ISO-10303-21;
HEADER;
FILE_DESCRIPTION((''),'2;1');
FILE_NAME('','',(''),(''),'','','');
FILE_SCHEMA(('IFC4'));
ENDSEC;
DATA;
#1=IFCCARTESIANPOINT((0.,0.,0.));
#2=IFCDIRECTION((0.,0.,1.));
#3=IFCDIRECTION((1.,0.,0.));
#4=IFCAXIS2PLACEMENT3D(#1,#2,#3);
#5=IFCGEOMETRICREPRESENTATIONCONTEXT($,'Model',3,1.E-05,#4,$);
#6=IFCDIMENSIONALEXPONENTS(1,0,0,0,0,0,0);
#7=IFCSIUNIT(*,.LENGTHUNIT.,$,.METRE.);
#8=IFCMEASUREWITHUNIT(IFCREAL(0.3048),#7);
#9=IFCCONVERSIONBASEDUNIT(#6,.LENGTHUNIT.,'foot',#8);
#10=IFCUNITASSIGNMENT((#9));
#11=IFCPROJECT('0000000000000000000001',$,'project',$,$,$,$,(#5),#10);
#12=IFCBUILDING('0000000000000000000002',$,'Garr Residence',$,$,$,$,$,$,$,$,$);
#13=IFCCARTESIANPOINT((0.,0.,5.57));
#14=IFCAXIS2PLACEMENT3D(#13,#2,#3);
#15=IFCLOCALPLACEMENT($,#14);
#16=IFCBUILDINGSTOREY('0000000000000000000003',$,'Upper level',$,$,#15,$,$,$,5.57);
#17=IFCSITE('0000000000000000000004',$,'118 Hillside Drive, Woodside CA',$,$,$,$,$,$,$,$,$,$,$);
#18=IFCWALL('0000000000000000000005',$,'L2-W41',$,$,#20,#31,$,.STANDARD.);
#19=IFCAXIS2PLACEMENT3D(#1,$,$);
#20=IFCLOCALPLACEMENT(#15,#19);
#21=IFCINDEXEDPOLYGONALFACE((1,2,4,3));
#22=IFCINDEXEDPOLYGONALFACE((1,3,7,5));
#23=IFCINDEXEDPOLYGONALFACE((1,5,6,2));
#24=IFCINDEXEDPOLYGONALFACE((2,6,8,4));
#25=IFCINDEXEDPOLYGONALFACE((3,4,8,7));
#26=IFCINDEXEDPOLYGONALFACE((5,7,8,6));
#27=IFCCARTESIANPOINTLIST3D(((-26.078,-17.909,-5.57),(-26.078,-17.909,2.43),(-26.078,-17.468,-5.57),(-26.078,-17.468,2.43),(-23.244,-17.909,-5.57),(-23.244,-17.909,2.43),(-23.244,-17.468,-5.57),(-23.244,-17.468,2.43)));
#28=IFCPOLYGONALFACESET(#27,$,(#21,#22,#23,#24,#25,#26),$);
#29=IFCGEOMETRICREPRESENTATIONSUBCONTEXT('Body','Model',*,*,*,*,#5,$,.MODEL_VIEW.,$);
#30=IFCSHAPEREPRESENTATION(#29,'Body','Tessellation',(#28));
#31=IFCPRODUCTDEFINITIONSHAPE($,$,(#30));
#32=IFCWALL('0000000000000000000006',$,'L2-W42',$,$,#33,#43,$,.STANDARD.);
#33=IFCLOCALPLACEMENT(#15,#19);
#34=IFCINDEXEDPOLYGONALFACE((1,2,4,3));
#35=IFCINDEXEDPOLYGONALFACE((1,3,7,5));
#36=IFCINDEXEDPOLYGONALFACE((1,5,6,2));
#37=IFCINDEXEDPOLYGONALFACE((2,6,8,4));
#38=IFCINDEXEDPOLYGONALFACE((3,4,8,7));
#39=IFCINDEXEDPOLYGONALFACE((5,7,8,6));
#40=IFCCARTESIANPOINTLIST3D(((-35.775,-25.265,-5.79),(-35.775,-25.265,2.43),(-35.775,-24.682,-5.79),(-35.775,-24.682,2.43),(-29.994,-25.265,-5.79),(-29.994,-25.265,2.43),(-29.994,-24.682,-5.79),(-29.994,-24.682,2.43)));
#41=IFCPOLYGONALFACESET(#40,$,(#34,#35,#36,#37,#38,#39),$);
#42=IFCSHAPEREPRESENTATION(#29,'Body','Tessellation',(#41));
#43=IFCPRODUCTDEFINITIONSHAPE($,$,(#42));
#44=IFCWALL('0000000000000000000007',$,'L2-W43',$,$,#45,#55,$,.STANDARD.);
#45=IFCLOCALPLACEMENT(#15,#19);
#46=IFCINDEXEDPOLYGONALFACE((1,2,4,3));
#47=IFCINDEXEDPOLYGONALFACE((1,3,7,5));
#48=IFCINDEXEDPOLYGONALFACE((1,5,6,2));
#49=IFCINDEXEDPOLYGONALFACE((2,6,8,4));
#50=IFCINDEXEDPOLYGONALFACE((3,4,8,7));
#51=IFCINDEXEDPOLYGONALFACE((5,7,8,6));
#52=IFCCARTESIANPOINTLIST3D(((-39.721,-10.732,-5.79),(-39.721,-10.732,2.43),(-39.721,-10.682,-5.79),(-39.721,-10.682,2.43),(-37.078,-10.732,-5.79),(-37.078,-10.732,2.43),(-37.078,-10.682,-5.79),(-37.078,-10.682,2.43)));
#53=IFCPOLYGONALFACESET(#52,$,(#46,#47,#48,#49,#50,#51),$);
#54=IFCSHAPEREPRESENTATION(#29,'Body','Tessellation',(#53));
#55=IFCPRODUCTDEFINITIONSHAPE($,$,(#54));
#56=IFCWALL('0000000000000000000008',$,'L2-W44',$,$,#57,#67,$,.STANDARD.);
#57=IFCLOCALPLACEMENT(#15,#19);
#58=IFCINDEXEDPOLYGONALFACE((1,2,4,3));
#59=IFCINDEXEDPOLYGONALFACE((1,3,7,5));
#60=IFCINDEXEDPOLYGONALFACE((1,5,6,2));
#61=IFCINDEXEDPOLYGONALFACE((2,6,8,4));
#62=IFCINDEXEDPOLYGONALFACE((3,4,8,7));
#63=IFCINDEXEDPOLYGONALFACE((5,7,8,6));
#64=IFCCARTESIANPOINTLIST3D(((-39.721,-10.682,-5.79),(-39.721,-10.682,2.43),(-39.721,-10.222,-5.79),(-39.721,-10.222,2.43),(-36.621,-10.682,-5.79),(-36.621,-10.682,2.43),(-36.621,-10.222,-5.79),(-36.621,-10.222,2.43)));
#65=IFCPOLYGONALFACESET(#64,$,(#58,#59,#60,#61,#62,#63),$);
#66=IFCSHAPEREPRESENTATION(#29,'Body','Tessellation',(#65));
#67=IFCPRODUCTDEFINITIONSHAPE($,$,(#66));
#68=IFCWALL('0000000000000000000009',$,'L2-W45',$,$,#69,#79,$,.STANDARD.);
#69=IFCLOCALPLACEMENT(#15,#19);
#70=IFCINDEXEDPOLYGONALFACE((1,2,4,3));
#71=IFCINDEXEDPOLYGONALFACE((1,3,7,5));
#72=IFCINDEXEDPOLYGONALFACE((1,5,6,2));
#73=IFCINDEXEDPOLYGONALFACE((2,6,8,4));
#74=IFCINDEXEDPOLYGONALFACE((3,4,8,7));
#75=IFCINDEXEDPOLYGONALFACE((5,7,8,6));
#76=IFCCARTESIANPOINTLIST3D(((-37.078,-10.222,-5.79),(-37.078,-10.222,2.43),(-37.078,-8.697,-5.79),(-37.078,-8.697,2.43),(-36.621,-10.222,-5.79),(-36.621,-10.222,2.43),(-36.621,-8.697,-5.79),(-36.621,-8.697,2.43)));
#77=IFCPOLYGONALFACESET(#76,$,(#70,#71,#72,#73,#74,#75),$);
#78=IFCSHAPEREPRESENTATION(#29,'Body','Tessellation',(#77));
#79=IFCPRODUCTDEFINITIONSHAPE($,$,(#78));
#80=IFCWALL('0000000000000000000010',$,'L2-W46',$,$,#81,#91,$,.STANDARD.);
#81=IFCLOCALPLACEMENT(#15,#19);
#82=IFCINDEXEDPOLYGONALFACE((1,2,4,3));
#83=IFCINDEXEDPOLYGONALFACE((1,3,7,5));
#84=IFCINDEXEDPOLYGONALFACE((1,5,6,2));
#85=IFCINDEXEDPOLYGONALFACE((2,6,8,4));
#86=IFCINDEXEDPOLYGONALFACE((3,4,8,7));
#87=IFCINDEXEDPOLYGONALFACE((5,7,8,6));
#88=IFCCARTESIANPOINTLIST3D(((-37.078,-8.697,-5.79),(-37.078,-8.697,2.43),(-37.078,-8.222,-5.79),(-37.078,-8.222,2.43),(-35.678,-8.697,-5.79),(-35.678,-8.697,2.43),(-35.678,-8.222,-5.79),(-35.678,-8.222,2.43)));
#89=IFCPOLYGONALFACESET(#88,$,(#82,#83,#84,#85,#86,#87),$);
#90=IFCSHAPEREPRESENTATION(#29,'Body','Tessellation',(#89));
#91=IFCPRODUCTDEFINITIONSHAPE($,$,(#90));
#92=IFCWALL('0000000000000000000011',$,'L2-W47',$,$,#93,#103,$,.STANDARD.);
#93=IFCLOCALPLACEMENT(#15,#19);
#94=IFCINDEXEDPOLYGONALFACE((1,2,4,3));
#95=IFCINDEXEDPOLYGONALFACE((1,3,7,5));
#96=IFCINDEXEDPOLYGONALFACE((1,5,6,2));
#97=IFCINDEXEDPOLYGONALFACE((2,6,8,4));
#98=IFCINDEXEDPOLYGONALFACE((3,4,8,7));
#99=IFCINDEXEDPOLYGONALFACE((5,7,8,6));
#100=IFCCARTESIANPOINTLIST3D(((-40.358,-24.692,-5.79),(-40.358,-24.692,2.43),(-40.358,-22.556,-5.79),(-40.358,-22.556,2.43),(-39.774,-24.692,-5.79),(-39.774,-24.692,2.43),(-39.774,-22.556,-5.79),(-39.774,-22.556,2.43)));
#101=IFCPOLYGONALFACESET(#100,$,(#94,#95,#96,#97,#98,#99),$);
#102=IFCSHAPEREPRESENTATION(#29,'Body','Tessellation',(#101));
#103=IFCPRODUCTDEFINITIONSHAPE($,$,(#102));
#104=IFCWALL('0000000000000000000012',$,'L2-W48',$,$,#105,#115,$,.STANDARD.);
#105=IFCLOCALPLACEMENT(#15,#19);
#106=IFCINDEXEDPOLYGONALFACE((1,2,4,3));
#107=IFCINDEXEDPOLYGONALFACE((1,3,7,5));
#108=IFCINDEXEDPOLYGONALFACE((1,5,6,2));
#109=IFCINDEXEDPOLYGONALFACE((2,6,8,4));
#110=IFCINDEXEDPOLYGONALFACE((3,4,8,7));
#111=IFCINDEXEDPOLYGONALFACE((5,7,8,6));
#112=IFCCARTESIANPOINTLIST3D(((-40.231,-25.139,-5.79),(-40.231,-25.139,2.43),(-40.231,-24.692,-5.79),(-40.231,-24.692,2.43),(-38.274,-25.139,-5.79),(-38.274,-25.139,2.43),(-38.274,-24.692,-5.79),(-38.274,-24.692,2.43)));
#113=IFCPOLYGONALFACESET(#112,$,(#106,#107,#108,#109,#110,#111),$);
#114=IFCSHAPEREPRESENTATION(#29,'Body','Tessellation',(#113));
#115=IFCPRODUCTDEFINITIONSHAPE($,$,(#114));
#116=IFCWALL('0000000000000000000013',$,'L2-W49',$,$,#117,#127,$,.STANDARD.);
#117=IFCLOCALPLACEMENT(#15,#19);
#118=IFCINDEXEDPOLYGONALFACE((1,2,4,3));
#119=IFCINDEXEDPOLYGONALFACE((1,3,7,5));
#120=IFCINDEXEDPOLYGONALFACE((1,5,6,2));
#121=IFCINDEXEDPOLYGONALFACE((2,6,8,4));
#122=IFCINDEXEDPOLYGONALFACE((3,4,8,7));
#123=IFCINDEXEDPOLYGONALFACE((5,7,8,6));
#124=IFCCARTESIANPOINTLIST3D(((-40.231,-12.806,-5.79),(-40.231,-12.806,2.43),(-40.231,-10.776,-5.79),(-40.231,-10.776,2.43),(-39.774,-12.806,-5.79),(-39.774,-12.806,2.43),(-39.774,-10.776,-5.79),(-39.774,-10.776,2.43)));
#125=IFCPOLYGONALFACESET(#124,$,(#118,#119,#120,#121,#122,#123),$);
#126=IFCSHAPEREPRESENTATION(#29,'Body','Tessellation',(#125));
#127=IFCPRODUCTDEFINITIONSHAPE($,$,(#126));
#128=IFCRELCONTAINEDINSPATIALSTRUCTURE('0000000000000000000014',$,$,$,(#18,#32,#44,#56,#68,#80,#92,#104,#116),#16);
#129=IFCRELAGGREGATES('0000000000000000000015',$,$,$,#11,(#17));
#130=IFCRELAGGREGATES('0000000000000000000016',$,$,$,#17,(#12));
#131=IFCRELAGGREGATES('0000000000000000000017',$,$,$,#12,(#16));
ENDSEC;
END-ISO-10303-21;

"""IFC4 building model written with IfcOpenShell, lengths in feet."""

from ifc_helpers import new_model, entity, si_unit, converted_unit, frame, origin, origin_with_axes, place, context, subcontext, project, spatial, polyline, outline, extrude, element, save


model = new_model("IFC4")

# Units and contexts
model_context = context("Model", 3, precision=1e-05, world=origin_with_axes())
body_context = subcontext(model_context, "Body", "Model", "MODEL_VIEW")
ifc_project = project(units=[converted_unit("LENGTHUNIT", "foot", entity("IfcReal", 0.3048), si_unit("LENGTHUNIT", "METRE"), dimensions=[1, 0, 0, 0, 0, 0, 0])], contexts=[model_context])

# Site, building, storey
site = spatial("IfcSite", under=ifc_project, Name="118 Hillside Drive, Woodside CA")
building = spatial("IfcBuilding", under=site, Name="Garr Residence")
storey_placement = place(None, frame((0.0, 0.0, 5.57), z_axis=(0.0, 0.0, 1.0), x_axis=(1.0, 0.0, 0.0)))
storey = spatial("IfcBuildingStorey", under=building, at=storey_placement, Name="Upper level", Elevation=5.57)

# Walls
wall_1_placement = place(storey_placement, frame((0.0, 0.0, -5.57), z_axis=(0.0, 0.0, 1.0), x_axis=(1.0, 0.0, 0.0)))
element("IfcWall", 1, at=wall_1_placement, inside=storey, Name="L2-W41", PredefinedType="STANDARD", context=body_context, shape_type="SweptSolid", body=[
    extrude(outline(polyline([(-23.244, -17.909), (-23.244, -17.468), (-26.078, -17.468), (-26.078, -17.909), (-23.244, -17.909)])), origin(), (0.0, 0.0, 1.0), 8.0),
])
wall_2_placement = place(storey_placement, frame((0.0, 0.0, -5.79), z_axis=(0.0, 0.0, 1.0), x_axis=(1.0, 0.0, 0.0)))
element("IfcWall", 2, at=wall_2_placement, inside=storey, Name="L2-W42", PredefinedType="STANDARD", context=body_context, shape_type="SweptSolid", body=[
    extrude(outline(polyline([(-29.994, -25.265), (-29.994, -24.682), (-35.775, -24.682), (-35.775, -25.265), (-29.994, -25.265)])), origin(), (0.0, 0.0, 1.0), 8.22),
])
wall_3_placement = place(storey_placement, frame((0.0, 0.0, -5.79), z_axis=(0.0, 0.0, 1.0), x_axis=(1.0, 0.0, 0.0)))
element("IfcWall", 3, at=wall_3_placement, inside=storey, Name="L2-W43", PredefinedType="STANDARD", context=body_context, shape_type="SweptSolid", body=[
    extrude(outline(polyline([(-37.078, -10.732), (-37.078, -10.682), (-39.721, -10.682), (-39.721, -10.732), (-37.078, -10.732)])), origin(), (0.0, 0.0, 1.0), 8.22),
])
wall_4_placement = place(storey_placement, frame((0.0, 0.0, -5.79), z_axis=(0.0, 0.0, 1.0), x_axis=(1.0, 0.0, 0.0)))
element("IfcWall", 4, at=wall_4_placement, inside=storey, Name="L2-W44", PredefinedType="STANDARD", context=body_context, shape_type="SweptSolid", body=[
    extrude(outline(polyline([(-36.621, -10.682), (-36.621, -10.222), (-39.721, -10.222), (-39.721, -10.682), (-36.621, -10.682)])), origin(), (0.0, 0.0, 1.0), 8.22),
])
wall_5_placement = place(storey_placement, frame((0.0, 0.0, -5.79), z_axis=(0.0, 0.0, 1.0), x_axis=(1.0, 0.0, 0.0)))
element("IfcWall", 5, at=wall_5_placement, inside=storey, Name="L2-W45", PredefinedType="STANDARD", context=body_context, shape_type="SweptSolid", body=[
    extrude(outline(polyline([(-36.621, -10.222), (-36.621, -8.697), (-37.078, -8.697), (-37.078, -10.222), (-36.621, -10.222)])), origin(), (0.0, 0.0, 1.0), 8.22),
])
wall_6_placement = place(storey_placement, frame((0.0, 0.0, -5.79), z_axis=(0.0, 0.0, 1.0), x_axis=(1.0, 0.0, 0.0)))
element("IfcWall", 6, at=wall_6_placement, inside=storey, Name="L2-W46", PredefinedType="STANDARD", context=body_context, shape_type="SweptSolid", body=[
    extrude(outline(polyline([(-35.678, -8.697), (-35.678, -8.222), (-37.078, -8.222), (-37.078, -8.697), (-35.678, -8.697)])), origin(), (0.0, 0.0, 1.0), 8.22),
])
wall_7_placement = place(storey_placement, frame((0.0, 0.0, -5.79), z_axis=(0.0, 0.0, 1.0), x_axis=(1.0, 0.0, 0.0)))
element("IfcWall", 7, at=wall_7_placement, inside=storey, Name="L2-W47", PredefinedType="STANDARD", context=body_context, shape_type="SweptSolid", body=[
    extrude(outline(polyline([(-39.774, -24.692), (-39.774, -22.556), (-40.358, -22.556), (-40.358, -24.692), (-39.774, -24.692)])), origin(), (0.0, 0.0, 1.0), 8.22),
])
wall_8_placement = place(storey_placement, frame((0.0, 0.0, -5.79), z_axis=(0.0, 0.0, 1.0), x_axis=(1.0, 0.0, 0.0)))
element("IfcWall", 8, at=wall_8_placement, inside=storey, Name="L2-W48", PredefinedType="STANDARD", context=body_context, shape_type="SweptSolid", body=[
    extrude(outline(polyline([(-38.274, -25.139), (-38.274, -24.692), (-40.231, -24.692), (-40.231, -25.139), (-38.274, -25.139)])), origin(), (0.0, 0.0, 1.0), 8.22),
])
wall_9_placement = place(storey_placement, frame((0.0, 0.0, -5.79), z_axis=(0.0, 0.0, 1.0), x_axis=(1.0, 0.0, 0.0)))
element("IfcWall", 9, at=wall_9_placement, inside=storey, Name="L2-W49", PredefinedType="STANDARD", context=body_context, shape_type="SweptSolid", body=[
    extrude(outline(polyline([(-39.774, -12.806), (-39.774, -10.776), (-40.231, -10.776), (-40.231, -12.806), (-39.774, -12.806)])), origin(), (0.0, 0.0, 1.0), 8.22),
])

save(model, "model.ifc")
